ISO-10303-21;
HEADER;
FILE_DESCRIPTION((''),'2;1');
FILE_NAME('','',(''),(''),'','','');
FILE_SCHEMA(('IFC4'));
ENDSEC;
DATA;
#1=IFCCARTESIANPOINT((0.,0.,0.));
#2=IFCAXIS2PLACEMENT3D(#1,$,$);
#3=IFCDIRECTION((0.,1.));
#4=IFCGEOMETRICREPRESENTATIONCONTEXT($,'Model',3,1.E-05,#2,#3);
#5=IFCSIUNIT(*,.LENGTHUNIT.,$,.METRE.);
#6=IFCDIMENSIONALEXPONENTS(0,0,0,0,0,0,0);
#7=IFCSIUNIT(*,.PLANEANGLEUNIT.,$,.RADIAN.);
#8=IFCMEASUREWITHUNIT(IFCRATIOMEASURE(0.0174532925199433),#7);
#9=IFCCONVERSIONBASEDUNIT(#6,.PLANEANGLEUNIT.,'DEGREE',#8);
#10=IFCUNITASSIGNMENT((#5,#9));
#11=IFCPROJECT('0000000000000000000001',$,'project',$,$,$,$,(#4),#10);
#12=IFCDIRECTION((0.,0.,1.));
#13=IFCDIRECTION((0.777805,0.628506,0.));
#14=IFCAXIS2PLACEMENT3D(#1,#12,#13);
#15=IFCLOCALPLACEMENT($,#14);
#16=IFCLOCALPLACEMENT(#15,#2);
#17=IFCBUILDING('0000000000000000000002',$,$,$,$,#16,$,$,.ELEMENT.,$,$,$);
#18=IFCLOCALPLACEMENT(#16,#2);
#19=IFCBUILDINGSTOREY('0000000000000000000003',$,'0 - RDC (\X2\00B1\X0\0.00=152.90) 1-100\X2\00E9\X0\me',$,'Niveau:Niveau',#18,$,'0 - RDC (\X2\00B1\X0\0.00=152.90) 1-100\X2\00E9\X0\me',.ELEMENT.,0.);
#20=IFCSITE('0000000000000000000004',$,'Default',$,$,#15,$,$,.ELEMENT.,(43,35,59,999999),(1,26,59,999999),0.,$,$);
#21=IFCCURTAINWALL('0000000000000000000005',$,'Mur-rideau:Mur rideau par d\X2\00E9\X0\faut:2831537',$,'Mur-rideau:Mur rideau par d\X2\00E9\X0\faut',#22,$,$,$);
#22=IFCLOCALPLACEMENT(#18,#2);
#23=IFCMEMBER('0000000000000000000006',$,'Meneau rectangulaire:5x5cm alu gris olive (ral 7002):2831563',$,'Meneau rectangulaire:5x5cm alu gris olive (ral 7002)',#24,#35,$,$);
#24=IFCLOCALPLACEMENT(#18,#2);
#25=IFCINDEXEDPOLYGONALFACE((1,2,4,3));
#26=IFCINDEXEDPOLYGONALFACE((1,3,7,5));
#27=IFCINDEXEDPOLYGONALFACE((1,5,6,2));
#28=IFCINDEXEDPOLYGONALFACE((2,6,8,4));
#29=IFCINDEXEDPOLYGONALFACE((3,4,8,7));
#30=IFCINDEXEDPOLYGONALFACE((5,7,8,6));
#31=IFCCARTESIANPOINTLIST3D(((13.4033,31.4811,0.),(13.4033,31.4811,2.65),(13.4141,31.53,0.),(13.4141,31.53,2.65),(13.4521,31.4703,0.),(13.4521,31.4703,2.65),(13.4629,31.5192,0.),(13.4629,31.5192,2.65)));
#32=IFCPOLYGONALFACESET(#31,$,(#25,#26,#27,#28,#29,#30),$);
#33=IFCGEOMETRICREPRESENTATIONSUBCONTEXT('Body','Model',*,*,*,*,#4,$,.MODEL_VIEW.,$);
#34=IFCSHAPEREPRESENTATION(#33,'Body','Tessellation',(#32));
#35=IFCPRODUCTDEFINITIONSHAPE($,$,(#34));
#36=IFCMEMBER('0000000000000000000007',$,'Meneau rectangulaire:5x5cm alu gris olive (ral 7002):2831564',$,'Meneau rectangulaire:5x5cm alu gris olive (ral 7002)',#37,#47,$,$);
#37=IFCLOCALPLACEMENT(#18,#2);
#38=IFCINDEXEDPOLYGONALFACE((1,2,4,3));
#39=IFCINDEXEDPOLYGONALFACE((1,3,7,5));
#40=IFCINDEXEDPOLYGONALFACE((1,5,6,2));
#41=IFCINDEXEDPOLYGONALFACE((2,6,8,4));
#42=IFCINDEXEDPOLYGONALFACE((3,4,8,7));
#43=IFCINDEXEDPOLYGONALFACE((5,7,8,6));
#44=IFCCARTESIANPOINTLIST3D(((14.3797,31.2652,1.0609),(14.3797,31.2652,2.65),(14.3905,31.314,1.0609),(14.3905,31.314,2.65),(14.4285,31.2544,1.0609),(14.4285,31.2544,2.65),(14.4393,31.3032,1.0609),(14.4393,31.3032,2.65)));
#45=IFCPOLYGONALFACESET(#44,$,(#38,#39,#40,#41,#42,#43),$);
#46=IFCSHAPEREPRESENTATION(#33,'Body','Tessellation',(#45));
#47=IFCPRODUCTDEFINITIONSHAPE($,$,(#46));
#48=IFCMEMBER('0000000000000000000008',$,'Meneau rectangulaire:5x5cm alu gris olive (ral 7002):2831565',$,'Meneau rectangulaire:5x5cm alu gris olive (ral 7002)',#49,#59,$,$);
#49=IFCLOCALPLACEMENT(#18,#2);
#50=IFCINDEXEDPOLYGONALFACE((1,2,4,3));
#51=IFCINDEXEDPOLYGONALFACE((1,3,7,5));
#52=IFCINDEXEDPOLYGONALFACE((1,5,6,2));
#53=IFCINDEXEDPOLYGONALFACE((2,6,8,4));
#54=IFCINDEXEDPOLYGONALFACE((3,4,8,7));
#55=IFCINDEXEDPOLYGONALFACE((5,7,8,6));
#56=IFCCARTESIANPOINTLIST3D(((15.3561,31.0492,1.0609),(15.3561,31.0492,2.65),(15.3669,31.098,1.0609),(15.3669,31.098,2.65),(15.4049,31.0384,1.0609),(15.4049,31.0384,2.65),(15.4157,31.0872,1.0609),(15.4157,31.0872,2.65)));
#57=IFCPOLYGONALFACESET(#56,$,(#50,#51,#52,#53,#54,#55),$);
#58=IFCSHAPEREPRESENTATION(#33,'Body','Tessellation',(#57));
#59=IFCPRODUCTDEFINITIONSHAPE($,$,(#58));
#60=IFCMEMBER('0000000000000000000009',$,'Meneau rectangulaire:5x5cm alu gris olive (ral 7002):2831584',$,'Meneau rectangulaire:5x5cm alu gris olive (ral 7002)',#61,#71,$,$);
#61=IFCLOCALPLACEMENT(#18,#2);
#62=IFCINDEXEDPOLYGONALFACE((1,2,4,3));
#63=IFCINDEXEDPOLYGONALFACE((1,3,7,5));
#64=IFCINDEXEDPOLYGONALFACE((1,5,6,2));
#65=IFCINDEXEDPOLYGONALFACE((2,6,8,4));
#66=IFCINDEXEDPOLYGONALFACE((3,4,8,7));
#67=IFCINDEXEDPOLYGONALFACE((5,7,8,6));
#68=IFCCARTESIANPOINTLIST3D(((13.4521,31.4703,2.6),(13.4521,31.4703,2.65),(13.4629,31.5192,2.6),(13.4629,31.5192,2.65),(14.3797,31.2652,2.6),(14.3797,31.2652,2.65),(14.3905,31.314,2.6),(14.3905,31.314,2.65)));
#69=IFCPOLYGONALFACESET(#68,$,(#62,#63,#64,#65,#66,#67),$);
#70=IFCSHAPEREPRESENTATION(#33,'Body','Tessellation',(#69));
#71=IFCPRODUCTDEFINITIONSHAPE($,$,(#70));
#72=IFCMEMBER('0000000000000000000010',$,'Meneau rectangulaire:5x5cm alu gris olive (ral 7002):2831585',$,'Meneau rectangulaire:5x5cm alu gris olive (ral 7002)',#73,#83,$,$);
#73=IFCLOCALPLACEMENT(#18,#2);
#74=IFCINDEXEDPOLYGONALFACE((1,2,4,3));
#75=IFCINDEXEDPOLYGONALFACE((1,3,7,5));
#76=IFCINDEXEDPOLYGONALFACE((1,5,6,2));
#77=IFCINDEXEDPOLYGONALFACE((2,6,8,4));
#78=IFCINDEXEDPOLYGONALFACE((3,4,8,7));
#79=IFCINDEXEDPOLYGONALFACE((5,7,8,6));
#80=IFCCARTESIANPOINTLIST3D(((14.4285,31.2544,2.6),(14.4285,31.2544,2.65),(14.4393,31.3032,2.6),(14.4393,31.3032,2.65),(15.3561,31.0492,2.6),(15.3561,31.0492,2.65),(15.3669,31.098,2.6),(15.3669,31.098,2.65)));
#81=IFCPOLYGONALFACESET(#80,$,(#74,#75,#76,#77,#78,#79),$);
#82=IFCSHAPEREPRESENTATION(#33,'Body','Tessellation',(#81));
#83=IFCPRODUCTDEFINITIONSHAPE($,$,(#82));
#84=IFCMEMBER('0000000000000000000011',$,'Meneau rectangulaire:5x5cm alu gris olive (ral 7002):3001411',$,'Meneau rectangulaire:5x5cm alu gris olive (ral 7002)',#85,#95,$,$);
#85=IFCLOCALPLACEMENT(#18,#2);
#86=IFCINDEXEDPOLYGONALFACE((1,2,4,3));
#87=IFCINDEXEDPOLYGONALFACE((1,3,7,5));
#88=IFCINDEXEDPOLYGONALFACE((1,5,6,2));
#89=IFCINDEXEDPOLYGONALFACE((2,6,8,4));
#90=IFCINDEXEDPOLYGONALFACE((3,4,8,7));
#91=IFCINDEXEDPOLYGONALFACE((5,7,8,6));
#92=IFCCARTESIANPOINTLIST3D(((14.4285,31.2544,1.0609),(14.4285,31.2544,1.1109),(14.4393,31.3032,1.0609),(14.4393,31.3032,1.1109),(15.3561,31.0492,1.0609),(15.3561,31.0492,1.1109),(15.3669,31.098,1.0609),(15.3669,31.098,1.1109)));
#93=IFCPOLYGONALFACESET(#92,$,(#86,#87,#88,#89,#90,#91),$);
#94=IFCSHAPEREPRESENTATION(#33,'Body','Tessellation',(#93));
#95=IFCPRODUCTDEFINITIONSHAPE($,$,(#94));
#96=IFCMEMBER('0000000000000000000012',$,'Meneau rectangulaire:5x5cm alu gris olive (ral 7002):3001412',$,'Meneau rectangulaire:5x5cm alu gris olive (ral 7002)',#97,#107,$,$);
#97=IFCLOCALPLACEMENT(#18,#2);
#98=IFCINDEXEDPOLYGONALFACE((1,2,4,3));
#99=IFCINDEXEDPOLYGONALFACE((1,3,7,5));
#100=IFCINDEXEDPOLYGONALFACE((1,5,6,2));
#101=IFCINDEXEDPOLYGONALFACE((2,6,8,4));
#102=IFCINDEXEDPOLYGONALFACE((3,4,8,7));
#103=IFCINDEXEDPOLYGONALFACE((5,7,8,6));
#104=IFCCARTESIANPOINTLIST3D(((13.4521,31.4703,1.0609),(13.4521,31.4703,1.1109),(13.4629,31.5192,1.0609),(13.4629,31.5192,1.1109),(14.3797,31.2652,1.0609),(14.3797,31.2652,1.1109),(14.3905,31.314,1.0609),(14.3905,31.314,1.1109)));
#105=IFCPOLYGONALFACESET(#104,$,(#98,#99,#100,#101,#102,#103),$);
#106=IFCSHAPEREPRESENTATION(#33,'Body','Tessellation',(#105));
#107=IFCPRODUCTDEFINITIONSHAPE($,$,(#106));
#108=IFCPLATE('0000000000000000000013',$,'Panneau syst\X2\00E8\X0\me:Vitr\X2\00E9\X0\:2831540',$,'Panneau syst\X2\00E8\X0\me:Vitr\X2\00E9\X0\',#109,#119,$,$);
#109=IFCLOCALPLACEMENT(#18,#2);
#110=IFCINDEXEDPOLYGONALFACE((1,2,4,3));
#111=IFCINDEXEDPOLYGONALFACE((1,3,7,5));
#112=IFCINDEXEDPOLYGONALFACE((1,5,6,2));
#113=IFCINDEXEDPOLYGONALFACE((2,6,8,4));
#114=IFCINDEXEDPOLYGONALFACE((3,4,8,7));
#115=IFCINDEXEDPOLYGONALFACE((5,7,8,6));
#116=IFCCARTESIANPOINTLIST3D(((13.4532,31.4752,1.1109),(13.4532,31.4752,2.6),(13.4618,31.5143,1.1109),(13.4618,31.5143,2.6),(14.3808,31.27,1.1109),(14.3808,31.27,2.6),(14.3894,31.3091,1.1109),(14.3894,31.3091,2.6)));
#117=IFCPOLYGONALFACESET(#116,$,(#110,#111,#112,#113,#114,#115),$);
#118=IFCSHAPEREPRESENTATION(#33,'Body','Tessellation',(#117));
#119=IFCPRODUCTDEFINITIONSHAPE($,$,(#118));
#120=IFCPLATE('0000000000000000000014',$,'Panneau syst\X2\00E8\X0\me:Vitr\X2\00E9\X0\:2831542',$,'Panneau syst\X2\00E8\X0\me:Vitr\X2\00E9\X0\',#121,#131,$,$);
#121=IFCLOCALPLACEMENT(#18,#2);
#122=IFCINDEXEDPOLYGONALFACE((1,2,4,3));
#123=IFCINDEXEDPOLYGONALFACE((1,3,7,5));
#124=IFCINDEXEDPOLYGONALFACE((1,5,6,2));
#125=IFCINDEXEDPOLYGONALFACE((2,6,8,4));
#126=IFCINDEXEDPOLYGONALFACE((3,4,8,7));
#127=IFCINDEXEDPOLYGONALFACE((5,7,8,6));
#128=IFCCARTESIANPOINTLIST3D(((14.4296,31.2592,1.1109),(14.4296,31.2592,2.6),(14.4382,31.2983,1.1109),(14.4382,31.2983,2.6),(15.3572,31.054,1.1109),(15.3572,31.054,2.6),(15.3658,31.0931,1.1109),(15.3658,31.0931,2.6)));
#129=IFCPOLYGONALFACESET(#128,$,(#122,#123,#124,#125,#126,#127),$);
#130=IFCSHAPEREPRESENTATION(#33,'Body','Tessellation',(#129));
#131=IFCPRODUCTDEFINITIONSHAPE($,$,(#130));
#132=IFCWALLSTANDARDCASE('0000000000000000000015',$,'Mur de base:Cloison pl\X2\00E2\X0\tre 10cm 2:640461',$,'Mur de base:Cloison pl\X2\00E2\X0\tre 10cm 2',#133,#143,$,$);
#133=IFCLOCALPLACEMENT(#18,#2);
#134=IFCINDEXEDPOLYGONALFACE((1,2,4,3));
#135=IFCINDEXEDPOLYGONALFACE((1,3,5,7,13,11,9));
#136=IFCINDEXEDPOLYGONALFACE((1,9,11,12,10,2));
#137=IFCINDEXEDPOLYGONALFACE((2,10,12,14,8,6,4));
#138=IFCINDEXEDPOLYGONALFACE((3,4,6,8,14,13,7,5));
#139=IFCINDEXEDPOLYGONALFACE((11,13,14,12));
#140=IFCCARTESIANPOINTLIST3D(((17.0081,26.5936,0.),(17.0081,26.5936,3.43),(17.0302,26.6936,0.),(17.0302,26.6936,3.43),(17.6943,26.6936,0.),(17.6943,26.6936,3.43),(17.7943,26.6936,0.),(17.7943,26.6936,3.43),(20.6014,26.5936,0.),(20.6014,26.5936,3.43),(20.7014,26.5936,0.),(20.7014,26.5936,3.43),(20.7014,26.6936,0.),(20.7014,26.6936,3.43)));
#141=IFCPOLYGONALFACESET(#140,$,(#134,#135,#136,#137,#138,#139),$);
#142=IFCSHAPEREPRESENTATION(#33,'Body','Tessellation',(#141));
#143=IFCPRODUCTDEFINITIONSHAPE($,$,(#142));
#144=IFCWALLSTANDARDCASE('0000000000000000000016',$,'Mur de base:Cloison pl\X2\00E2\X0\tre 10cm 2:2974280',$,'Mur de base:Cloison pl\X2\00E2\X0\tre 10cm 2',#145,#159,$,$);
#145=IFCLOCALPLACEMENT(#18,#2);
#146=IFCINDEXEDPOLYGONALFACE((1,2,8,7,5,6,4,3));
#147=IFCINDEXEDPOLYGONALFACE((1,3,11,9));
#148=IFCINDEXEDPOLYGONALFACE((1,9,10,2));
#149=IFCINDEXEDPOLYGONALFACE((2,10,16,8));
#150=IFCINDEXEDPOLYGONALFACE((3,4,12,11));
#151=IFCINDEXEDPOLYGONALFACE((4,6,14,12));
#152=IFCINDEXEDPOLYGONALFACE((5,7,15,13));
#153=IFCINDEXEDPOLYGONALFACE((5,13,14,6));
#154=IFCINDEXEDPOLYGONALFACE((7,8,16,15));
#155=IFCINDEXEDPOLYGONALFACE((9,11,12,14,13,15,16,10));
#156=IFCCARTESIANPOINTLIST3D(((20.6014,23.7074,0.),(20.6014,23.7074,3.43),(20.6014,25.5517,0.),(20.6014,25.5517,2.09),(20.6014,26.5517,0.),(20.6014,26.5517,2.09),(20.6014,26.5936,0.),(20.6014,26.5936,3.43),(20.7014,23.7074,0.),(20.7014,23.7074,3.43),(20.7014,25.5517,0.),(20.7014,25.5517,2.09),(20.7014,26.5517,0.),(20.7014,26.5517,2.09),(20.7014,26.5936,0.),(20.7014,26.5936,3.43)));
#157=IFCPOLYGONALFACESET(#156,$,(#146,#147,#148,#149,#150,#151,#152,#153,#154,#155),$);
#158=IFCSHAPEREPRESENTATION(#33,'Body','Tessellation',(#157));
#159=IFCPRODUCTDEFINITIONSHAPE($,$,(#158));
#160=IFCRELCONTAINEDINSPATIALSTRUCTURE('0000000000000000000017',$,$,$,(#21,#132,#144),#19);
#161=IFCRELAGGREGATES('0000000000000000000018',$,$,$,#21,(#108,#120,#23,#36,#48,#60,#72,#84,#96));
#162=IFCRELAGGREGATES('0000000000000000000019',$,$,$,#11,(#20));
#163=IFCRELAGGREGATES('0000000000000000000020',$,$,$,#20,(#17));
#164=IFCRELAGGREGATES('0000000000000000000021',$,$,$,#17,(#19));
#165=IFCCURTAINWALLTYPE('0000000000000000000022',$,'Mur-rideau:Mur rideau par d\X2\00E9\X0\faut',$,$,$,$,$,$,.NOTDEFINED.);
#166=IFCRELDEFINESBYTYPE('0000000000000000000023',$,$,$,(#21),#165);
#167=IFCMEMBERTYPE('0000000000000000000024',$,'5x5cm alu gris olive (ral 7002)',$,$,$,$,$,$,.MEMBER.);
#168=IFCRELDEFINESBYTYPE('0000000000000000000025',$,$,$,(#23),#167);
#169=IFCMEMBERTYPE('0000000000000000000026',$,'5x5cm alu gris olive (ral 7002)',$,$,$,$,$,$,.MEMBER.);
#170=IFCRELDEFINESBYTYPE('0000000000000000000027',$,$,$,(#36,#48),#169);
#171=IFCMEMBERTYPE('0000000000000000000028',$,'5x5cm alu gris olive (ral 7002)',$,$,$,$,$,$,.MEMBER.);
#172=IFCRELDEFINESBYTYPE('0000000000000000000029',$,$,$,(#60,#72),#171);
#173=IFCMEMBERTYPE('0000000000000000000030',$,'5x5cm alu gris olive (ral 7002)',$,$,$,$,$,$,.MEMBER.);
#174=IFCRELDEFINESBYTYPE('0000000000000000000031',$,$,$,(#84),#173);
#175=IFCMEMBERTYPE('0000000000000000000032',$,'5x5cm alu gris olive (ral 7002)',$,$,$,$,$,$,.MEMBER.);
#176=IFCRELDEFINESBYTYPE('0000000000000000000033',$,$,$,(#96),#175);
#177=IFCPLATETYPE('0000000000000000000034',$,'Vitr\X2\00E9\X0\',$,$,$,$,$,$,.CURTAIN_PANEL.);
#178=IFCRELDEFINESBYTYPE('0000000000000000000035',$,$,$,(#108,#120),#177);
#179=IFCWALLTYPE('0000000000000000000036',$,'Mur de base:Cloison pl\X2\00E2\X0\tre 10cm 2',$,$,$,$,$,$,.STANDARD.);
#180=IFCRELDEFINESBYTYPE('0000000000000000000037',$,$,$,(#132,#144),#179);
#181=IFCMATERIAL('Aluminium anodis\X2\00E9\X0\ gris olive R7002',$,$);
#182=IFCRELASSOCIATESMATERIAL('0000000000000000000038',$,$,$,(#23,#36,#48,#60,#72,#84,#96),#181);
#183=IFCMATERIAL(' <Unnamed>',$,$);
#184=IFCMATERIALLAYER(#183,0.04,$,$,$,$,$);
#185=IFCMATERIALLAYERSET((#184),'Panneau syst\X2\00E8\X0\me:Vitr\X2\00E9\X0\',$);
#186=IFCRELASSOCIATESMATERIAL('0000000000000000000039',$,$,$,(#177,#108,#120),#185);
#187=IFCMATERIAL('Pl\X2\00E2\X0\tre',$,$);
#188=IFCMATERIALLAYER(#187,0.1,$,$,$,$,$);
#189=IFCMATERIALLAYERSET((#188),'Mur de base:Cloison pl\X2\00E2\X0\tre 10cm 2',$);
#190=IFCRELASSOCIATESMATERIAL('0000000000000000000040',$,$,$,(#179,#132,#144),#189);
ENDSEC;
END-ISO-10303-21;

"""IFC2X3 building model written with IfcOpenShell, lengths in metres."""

from ifc_helpers import new_model, entity, si_unit, converted_unit, direction, frame, frame_2d, origin, origin_2d_with_axis, place, context, subcontext, project, spatial, polyline, rectangle, outline, extrude, source, transform, mapped, material, layer, layer_set, layer_usage, type_object, type_shapes, element, aggregate, save


model = new_model("IFC2X3")

# Units and contexts
model_context = context("Model", 3, precision=1e-05, world=origin(), true_north=direction((0.0, 1.0)))
body_context = subcontext(model_context, "Body", "Model", "MODEL_VIEW")
ifc_project = project(units=[si_unit("LENGTHUNIT", "METRE"), converted_unit("PLANEANGLEUNIT", "DEGREE", entity("IfcRatioMeasure", 0.0174532925199433), si_unit("PLANEANGLEUNIT", "RADIAN"), dimensions=[0, 0, 0, 0, 0, 0, 0])], contexts=[model_context])

# Site, building, storey
site_placement = place(None, frame((0.0, 0.0, 0.0), z_axis=(0.0, 0.0, 1.0), x_axis=(0.777805, 0.628506, 0.0)))
site = spatial("IfcSite", under=ifc_project, at=site_placement, Name="Default", CompositionType="ELEMENT", RefLatitude=(43, 35, 59, 999999), RefLongitude=(1, 26, 59, 999999), RefElevation=0.0)
building_placement = place(site_placement, origin())
building = spatial("IfcBuilding", under=site, at=building_placement, CompositionType="ELEMENT")
storey_placement = place(building_placement, origin())
storey = spatial("IfcBuildingStorey", under=building, at=storey_placement, Name="0 - RDC (±0.00=152.90) 1-100éme", ObjectType="Niveau:Niveau", LongName="0 - RDC (±0.00=152.90) 1-100éme", CompositionType="ELEMENT", Elevation=0.0)

# Curtain wall, members, plates
curtain_wall_type = type_object("IfcCurtainWallType", Name="Mur-rideau:Mur rideau par défaut", PredefinedType="NOTDEFINED")
curtain_wall_placement = place(storey_placement, origin())
curtain_wall = element("IfcCurtainWall", 1, at=curtain_wall_placement, inside=storey, type_object=curtain_wall_type, Name="Mur-rideau:Mur rideau par défaut:2831537", ObjectType="Mur-rideau:Mur rideau par défaut")
ifc_material_1 = material(Name="Aluminium anodisé gris olive R7002")
member_type_1 = type_object("IfcMemberType", Name="5x5cm alu gris olive (ral 7002)", PredefinedType="MEMBER")
shared_shape_1 = source(origin(), body_context, "Body", "SweptSolid", [
    extrude(rectangle(XDim=0.05, YDim=0.05, at=origin_2d_with_axis()), frame((0.0, 0.0, -2.65), z_axis=(0.0, 0.0, 1.0), x_axis=(0.0, -1.0, 0.0)), (0.0, 0.0, 1.0), 2.65),
])
type_shapes(member_type_1, [shared_shape_1])
member_1_placement = place(storey_placement, frame((13.4331, 31.5001, 0.0), z_axis=(0.0, 0.0, -1.0), x_axis=(0.976397, -0.215985, 0.0)))
member_1 = element("IfcMember", 2, at=member_1_placement, type_object=member_type_1, material=ifc_material_1, Name="Meneau rectangulaire:5x5cm alu gris olive (ral 7002):2831563", ObjectType="Meneau rectangulaire:5x5cm alu gris olive (ral 7002)", context=body_context, shape_type="MappedRepresentation", body=[
    mapped(shared_shape_1, transform((0.0, 0.0, 0.0), scale=1.0)),
])
member_type_2 = type_object("IfcMemberType", Name="5x5cm alu gris olive (ral 7002)", PredefinedType="MEMBER")
shared_shape_2 = source(origin(), body_context, "Body", "SweptSolid", [
    extrude(rectangle(XDim=0.05, YDim=0.05, at=origin_2d_with_axis()), frame((0.0, 0.0, -1.5891), z_axis=(0.0, 0.0, 1.0), x_axis=(0.0, -1.0, 0.0)), (0.0, 0.0, 1.0), 1.5891),
])
type_shapes(member_type_2, [shared_shape_2])
member_2_placement = place(storey_placement, frame((14.4095, 31.2842, 1.0609), z_axis=(0.0, 0.0, -1.0), x_axis=(0.976397, -0.215985, 0.0)))
member_2 = element("IfcMember", 3, at=member_2_placement, type_object=member_type_2, material=ifc_material_1, Name="Meneau rectangulaire:5x5cm alu gris olive (ral 7002):2831564", ObjectType="Meneau rectangulaire:5x5cm alu gris olive (ral 7002)", context=body_context, shape_type="MappedRepresentation", body=[
    mapped(shared_shape_2, transform((0.0, 0.0, 0.0), scale=1.0)),
])
member_3_placement = place(storey_placement, frame((15.3859, 31.0682, 1.0609), z_axis=(0.0, 0.0, -1.0), x_axis=(0.976397, -0.215985, 0.0)))
member_3 = element("IfcMember", 4, at=member_3_placement, type_object=member_type_2, material=ifc_material_1, Name="Meneau rectangulaire:5x5cm alu gris olive (ral 7002):2831565", ObjectType="Meneau rectangulaire:5x5cm alu gris olive (ral 7002)", context=body_context, shape_type="MappedRepresentation", body=[
    mapped(shared_shape_2, transform((0.0, 0.0, 0.0), scale=1.0)),
])
member_type_3 = type_object("IfcMemberType", Name="5x5cm alu gris olive (ral 7002)", PredefinedType="MEMBER")
shared_shape_3 = source(origin(), body_context, "Body", "SweptSolid", [
    extrude(rectangle(XDim=0.05, YDim=0.05, at=origin_2d_with_axis()), frame((-0.025, 0.0, -0.95), z_axis=(0.0, 0.0, 1.0), x_axis=(0.0, -1.0, 0.0)), (0.0, 0.0, 1.0), 0.95),
])
type_shapes(member_type_3, [shared_shape_3])
member_4_placement = place(storey_placement, frame((14.3851, 31.2896, 2.65), z_axis=(0.976397, -0.215985, 0.0), x_axis=(0.0, 0.0, 1.0)))
member_4 = element("IfcMember", 5, at=member_4_placement, type_object=member_type_3, material=ifc_material_1, Name="Meneau rectangulaire:5x5cm alu gris olive (ral 7002):2831584", ObjectType="Meneau rectangulaire:5x5cm alu gris olive (ral 7002)", context=body_context, shape_type="MappedRepresentation", body=[
    mapped(shared_shape_3, transform((0.0, 0.0, 0.0), scale=1.0)),
])
member_5_placement = place(storey_placement, frame((15.3615, 31.0736, 2.65), z_axis=(0.976397, -0.215985, 0.0), x_axis=(0.0, 0.0, 1.0)))
member_5 = element("IfcMember", 6, at=member_5_placement, type_object=member_type_3, material=ifc_material_1, Name="Meneau rectangulaire:5x5cm alu gris olive (ral 7002):2831585", ObjectType="Meneau rectangulaire:5x5cm alu gris olive (ral 7002)", context=body_context, shape_type="MappedRepresentation", body=[
    mapped(shared_shape_3, transform((0.0, 0.0, 0.0), scale=1.0)),
])
member_type_4 = type_object("IfcMemberType", Name="5x5cm alu gris olive (ral 7002)", PredefinedType="MEMBER")
shared_shape_4 = source(origin(), body_context, "Body", "SweptSolid", [
    extrude(rectangle(XDim=0.05, YDim=0.05, at=origin_2d_with_axis()), frame((-0.025, 0.0, -0.95), z_axis=(0.0, 0.0, 1.0), x_axis=(0.0, -1.0, 0.0)), (0.0, 0.0, 1.0), 0.95),
])
type_shapes(member_type_4, [shared_shape_4])
member_6_placement = place(storey_placement, frame((14.4339, 31.2788, 1.0609), z_axis=(-0.976397, 0.215985, 0.0), x_axis=(0.0, 0.0, -1.0)))
member_6 = element("IfcMember", 7, at=member_6_placement, type_object=member_type_4, material=ifc_material_1, Name="Meneau rectangulaire:5x5cm alu gris olive (ral 7002):3001411", ObjectType="Meneau rectangulaire:5x5cm alu gris olive (ral 7002)", context=body_context, shape_type="MappedRepresentation", body=[
    mapped(shared_shape_4, transform((0.0, 0.0, 0.0), scale=1.0)),
])
member_type_5 = type_object("IfcMemberType", Name="5x5cm alu gris olive (ral 7002)", PredefinedType="MEMBER")
shared_shape_5 = source(origin(), body_context, "Body", "SweptSolid", [
    extrude(rectangle(XDim=0.05, YDim=0.05, at=origin_2d_with_axis()), frame((-0.025, 0.0, -0.95), z_axis=(0.0, 0.0, 1.0), x_axis=(0.0, -1.0, 0.0)), (0.0, 0.0, 1.0), 0.95),
])
type_shapes(member_type_5, [shared_shape_5])
member_7_placement = place(storey_placement, frame((13.4575, 31.4947, 1.0609), z_axis=(-0.976397, 0.215985, 0.0), x_axis=(0.0, 0.0, -1.0)))
member_7 = element("IfcMember", 8, at=member_7_placement, type_object=member_type_5, material=ifc_material_1, Name="Meneau rectangulaire:5x5cm alu gris olive (ral 7002):3001412", ObjectType="Meneau rectangulaire:5x5cm alu gris olive (ral 7002)", context=body_context, shape_type="MappedRepresentation", body=[
    mapped(shared_shape_5, transform((0.0, 0.0, 0.0), scale=1.0)),
])
ifc_material_2 = material(Name=" <Unnamed>")
ifc_layer_1 = layer(ifc_material_2, 0.04)
ifc_layer_set_1 = layer_set([ifc_layer_1], Name="Panneau système:Vitré")
ifc_layer_usage_1 = layer_usage(ifc_layer_set_1, "AXIS3", "POSITIVE", 0.0)
plate_type = type_object("IfcPlateType", Name="Vitré", PredefinedType="CURTAIN_PANEL", material=ifc_layer_set_1)
shared_shape_6 = source(origin(), body_context, "Body", "SweptSolid", [
    extrude(rectangle(XDim=0.04, YDim=0.95, at=frame_2d((0.0, 0.0), x_axis=(1.0, 0.0))), frame((0.0, 0.0, 0.0), z_axis=(0.0, 0.0, 1.0), x_axis=(0.0, 1.0, 0.0)), (0.0, 0.0, 1.0), 1.4891),
])
type_shapes(plate_type, [shared_shape_6])
plate_1_placement = place(curtain_wall_placement, frame((13.9213, 31.3922, 1.1109), z_axis=(0.0, 0.0, 1.0), x_axis=(0.976397, -0.215985, 0.0)))
plate_1 = element("IfcPlate", 9, at=plate_1_placement, type_object=plate_type, material=ifc_layer_usage_1, Name="Panneau système:Vitré:2831540", ObjectType="Panneau système:Vitré", context=body_context, shape_type="MappedRepresentation", body=[
    mapped(shared_shape_6, transform((0.0, 0.0, 0.0), scale=1.0)),
])
ifc_layer_usage_2 = layer_usage(ifc_layer_set_1, "AXIS3", "POSITIVE", 0.0)
plate_2_placement = place(curtain_wall_placement, frame((14.8977, 31.1762, 1.1109), z_axis=(0.0, 0.0, 1.0), x_axis=(0.976397, -0.215985, 0.0)))
plate_2 = element("IfcPlate", 10, at=plate_2_placement, type_object=plate_type, material=ifc_layer_usage_2, Name="Panneau système:Vitré:2831542", ObjectType="Panneau système:Vitré", context=body_context, shape_type="MappedRepresentation", body=[
    mapped(shared_shape_6, transform((0.0, 0.0, 0.0), scale=1.0)),
])
aggregate(curtain_wall, [plate_1, plate_2, member_1, member_2, member_3, member_4, member_5, member_6, member_7])

# Wall
ifc_material_3 = material(Name="Plâtre")
ifc_layer_2 = layer(ifc_material_3, 0.1)
ifc_layer_set_2 = layer_set([ifc_layer_2], Name="Mur de base:Cloison plâtre 10cm 2")
ifc_layer_usage_3 = layer_usage(ifc_layer_set_2, "AXIS2", "NEGATIVE", 0.05)
wall_type_1 = type_object("IfcWallType", Name="Mur de base:Cloison plâtre 10cm 2", PredefinedType="STANDARD", material=ifc_layer_set_2)
wall_1_placement = place(storey_placement, frame((20.7014, 26.6436, 0.0), z_axis=(0.0, 0.0, 1.0), x_axis=(-1.0, 0.0, 0.0)))
element("IfcWallStandardCase", 11, at=wall_1_placement, inside=storey, type_object=wall_type_1, material=ifc_layer_usage_3, Name="Mur de base:Cloison plâtre 10cm 2:640461", ObjectType="Mur de base:Cloison plâtre 10cm 2", context=body_context, shape_type="SweptSolid", body=[
    extrude(outline(polyline([(3.6712, -0.05), (3.6933, 0.05), (0.1, 0.05), (0.0, 0.05), (0.0, -0.05), (2.9071, -0.05), (3.0071, -0.05), (3.6712, -0.05)])), origin(), (0.0, 0.0, 1.0), 3.43),
])

# Wall, opening
ifc_layer_usage_4 = layer_usage(ifc_layer_set_2, "AXIS2", "NEGATIVE", 0.05)
wall_2_placement = place(storey_placement, frame((20.6514, 26.5936, 0.0), z_axis=(0.0, 0.0, 1.0), x_axis=(0.0, -1.0, 0.0)))
wall_2 = element("IfcWallStandardCase", 12, at=wall_2_placement, inside=storey, type_object=wall_type_1, material=ifc_layer_usage_4, Name="Mur de base:Cloison plâtre 10cm 2:2974280", ObjectType="Mur de base:Cloison plâtre 10cm 2", context=body_context, shape_type="SweptSolid", body=[
    extrude(rectangle(XDim=2.8862, YDim=0.1, at=frame_2d((1.4431, 0.0), x_axis=(-1.0, 0.0))), origin(), (0.0, 0.0, 1.0), 3.43),
])
opening_1_placement = place(wall_2_placement, frame((1.0419, 0.05, 0.0)))
element("IfcOpeningElement", 13, at=opening_1_placement, cuts=wall_2, ObjectType="Opening", context=body_context, shape_type="SweptSolid", body=[
    extrude(rectangle(XDim=2.09, YDim=1.0, at=frame_2d((1.045, 0.5), x_axis=(1.0, 0.0))), frame((0.0, 0.0, 0.0), z_axis=(0.0, -1.0, 0.0), x_axis=(0.0, 0.0, 1.0)), (0.0, 0.0, 1.0), 0.1),
])

save(model, "model.ifc")
